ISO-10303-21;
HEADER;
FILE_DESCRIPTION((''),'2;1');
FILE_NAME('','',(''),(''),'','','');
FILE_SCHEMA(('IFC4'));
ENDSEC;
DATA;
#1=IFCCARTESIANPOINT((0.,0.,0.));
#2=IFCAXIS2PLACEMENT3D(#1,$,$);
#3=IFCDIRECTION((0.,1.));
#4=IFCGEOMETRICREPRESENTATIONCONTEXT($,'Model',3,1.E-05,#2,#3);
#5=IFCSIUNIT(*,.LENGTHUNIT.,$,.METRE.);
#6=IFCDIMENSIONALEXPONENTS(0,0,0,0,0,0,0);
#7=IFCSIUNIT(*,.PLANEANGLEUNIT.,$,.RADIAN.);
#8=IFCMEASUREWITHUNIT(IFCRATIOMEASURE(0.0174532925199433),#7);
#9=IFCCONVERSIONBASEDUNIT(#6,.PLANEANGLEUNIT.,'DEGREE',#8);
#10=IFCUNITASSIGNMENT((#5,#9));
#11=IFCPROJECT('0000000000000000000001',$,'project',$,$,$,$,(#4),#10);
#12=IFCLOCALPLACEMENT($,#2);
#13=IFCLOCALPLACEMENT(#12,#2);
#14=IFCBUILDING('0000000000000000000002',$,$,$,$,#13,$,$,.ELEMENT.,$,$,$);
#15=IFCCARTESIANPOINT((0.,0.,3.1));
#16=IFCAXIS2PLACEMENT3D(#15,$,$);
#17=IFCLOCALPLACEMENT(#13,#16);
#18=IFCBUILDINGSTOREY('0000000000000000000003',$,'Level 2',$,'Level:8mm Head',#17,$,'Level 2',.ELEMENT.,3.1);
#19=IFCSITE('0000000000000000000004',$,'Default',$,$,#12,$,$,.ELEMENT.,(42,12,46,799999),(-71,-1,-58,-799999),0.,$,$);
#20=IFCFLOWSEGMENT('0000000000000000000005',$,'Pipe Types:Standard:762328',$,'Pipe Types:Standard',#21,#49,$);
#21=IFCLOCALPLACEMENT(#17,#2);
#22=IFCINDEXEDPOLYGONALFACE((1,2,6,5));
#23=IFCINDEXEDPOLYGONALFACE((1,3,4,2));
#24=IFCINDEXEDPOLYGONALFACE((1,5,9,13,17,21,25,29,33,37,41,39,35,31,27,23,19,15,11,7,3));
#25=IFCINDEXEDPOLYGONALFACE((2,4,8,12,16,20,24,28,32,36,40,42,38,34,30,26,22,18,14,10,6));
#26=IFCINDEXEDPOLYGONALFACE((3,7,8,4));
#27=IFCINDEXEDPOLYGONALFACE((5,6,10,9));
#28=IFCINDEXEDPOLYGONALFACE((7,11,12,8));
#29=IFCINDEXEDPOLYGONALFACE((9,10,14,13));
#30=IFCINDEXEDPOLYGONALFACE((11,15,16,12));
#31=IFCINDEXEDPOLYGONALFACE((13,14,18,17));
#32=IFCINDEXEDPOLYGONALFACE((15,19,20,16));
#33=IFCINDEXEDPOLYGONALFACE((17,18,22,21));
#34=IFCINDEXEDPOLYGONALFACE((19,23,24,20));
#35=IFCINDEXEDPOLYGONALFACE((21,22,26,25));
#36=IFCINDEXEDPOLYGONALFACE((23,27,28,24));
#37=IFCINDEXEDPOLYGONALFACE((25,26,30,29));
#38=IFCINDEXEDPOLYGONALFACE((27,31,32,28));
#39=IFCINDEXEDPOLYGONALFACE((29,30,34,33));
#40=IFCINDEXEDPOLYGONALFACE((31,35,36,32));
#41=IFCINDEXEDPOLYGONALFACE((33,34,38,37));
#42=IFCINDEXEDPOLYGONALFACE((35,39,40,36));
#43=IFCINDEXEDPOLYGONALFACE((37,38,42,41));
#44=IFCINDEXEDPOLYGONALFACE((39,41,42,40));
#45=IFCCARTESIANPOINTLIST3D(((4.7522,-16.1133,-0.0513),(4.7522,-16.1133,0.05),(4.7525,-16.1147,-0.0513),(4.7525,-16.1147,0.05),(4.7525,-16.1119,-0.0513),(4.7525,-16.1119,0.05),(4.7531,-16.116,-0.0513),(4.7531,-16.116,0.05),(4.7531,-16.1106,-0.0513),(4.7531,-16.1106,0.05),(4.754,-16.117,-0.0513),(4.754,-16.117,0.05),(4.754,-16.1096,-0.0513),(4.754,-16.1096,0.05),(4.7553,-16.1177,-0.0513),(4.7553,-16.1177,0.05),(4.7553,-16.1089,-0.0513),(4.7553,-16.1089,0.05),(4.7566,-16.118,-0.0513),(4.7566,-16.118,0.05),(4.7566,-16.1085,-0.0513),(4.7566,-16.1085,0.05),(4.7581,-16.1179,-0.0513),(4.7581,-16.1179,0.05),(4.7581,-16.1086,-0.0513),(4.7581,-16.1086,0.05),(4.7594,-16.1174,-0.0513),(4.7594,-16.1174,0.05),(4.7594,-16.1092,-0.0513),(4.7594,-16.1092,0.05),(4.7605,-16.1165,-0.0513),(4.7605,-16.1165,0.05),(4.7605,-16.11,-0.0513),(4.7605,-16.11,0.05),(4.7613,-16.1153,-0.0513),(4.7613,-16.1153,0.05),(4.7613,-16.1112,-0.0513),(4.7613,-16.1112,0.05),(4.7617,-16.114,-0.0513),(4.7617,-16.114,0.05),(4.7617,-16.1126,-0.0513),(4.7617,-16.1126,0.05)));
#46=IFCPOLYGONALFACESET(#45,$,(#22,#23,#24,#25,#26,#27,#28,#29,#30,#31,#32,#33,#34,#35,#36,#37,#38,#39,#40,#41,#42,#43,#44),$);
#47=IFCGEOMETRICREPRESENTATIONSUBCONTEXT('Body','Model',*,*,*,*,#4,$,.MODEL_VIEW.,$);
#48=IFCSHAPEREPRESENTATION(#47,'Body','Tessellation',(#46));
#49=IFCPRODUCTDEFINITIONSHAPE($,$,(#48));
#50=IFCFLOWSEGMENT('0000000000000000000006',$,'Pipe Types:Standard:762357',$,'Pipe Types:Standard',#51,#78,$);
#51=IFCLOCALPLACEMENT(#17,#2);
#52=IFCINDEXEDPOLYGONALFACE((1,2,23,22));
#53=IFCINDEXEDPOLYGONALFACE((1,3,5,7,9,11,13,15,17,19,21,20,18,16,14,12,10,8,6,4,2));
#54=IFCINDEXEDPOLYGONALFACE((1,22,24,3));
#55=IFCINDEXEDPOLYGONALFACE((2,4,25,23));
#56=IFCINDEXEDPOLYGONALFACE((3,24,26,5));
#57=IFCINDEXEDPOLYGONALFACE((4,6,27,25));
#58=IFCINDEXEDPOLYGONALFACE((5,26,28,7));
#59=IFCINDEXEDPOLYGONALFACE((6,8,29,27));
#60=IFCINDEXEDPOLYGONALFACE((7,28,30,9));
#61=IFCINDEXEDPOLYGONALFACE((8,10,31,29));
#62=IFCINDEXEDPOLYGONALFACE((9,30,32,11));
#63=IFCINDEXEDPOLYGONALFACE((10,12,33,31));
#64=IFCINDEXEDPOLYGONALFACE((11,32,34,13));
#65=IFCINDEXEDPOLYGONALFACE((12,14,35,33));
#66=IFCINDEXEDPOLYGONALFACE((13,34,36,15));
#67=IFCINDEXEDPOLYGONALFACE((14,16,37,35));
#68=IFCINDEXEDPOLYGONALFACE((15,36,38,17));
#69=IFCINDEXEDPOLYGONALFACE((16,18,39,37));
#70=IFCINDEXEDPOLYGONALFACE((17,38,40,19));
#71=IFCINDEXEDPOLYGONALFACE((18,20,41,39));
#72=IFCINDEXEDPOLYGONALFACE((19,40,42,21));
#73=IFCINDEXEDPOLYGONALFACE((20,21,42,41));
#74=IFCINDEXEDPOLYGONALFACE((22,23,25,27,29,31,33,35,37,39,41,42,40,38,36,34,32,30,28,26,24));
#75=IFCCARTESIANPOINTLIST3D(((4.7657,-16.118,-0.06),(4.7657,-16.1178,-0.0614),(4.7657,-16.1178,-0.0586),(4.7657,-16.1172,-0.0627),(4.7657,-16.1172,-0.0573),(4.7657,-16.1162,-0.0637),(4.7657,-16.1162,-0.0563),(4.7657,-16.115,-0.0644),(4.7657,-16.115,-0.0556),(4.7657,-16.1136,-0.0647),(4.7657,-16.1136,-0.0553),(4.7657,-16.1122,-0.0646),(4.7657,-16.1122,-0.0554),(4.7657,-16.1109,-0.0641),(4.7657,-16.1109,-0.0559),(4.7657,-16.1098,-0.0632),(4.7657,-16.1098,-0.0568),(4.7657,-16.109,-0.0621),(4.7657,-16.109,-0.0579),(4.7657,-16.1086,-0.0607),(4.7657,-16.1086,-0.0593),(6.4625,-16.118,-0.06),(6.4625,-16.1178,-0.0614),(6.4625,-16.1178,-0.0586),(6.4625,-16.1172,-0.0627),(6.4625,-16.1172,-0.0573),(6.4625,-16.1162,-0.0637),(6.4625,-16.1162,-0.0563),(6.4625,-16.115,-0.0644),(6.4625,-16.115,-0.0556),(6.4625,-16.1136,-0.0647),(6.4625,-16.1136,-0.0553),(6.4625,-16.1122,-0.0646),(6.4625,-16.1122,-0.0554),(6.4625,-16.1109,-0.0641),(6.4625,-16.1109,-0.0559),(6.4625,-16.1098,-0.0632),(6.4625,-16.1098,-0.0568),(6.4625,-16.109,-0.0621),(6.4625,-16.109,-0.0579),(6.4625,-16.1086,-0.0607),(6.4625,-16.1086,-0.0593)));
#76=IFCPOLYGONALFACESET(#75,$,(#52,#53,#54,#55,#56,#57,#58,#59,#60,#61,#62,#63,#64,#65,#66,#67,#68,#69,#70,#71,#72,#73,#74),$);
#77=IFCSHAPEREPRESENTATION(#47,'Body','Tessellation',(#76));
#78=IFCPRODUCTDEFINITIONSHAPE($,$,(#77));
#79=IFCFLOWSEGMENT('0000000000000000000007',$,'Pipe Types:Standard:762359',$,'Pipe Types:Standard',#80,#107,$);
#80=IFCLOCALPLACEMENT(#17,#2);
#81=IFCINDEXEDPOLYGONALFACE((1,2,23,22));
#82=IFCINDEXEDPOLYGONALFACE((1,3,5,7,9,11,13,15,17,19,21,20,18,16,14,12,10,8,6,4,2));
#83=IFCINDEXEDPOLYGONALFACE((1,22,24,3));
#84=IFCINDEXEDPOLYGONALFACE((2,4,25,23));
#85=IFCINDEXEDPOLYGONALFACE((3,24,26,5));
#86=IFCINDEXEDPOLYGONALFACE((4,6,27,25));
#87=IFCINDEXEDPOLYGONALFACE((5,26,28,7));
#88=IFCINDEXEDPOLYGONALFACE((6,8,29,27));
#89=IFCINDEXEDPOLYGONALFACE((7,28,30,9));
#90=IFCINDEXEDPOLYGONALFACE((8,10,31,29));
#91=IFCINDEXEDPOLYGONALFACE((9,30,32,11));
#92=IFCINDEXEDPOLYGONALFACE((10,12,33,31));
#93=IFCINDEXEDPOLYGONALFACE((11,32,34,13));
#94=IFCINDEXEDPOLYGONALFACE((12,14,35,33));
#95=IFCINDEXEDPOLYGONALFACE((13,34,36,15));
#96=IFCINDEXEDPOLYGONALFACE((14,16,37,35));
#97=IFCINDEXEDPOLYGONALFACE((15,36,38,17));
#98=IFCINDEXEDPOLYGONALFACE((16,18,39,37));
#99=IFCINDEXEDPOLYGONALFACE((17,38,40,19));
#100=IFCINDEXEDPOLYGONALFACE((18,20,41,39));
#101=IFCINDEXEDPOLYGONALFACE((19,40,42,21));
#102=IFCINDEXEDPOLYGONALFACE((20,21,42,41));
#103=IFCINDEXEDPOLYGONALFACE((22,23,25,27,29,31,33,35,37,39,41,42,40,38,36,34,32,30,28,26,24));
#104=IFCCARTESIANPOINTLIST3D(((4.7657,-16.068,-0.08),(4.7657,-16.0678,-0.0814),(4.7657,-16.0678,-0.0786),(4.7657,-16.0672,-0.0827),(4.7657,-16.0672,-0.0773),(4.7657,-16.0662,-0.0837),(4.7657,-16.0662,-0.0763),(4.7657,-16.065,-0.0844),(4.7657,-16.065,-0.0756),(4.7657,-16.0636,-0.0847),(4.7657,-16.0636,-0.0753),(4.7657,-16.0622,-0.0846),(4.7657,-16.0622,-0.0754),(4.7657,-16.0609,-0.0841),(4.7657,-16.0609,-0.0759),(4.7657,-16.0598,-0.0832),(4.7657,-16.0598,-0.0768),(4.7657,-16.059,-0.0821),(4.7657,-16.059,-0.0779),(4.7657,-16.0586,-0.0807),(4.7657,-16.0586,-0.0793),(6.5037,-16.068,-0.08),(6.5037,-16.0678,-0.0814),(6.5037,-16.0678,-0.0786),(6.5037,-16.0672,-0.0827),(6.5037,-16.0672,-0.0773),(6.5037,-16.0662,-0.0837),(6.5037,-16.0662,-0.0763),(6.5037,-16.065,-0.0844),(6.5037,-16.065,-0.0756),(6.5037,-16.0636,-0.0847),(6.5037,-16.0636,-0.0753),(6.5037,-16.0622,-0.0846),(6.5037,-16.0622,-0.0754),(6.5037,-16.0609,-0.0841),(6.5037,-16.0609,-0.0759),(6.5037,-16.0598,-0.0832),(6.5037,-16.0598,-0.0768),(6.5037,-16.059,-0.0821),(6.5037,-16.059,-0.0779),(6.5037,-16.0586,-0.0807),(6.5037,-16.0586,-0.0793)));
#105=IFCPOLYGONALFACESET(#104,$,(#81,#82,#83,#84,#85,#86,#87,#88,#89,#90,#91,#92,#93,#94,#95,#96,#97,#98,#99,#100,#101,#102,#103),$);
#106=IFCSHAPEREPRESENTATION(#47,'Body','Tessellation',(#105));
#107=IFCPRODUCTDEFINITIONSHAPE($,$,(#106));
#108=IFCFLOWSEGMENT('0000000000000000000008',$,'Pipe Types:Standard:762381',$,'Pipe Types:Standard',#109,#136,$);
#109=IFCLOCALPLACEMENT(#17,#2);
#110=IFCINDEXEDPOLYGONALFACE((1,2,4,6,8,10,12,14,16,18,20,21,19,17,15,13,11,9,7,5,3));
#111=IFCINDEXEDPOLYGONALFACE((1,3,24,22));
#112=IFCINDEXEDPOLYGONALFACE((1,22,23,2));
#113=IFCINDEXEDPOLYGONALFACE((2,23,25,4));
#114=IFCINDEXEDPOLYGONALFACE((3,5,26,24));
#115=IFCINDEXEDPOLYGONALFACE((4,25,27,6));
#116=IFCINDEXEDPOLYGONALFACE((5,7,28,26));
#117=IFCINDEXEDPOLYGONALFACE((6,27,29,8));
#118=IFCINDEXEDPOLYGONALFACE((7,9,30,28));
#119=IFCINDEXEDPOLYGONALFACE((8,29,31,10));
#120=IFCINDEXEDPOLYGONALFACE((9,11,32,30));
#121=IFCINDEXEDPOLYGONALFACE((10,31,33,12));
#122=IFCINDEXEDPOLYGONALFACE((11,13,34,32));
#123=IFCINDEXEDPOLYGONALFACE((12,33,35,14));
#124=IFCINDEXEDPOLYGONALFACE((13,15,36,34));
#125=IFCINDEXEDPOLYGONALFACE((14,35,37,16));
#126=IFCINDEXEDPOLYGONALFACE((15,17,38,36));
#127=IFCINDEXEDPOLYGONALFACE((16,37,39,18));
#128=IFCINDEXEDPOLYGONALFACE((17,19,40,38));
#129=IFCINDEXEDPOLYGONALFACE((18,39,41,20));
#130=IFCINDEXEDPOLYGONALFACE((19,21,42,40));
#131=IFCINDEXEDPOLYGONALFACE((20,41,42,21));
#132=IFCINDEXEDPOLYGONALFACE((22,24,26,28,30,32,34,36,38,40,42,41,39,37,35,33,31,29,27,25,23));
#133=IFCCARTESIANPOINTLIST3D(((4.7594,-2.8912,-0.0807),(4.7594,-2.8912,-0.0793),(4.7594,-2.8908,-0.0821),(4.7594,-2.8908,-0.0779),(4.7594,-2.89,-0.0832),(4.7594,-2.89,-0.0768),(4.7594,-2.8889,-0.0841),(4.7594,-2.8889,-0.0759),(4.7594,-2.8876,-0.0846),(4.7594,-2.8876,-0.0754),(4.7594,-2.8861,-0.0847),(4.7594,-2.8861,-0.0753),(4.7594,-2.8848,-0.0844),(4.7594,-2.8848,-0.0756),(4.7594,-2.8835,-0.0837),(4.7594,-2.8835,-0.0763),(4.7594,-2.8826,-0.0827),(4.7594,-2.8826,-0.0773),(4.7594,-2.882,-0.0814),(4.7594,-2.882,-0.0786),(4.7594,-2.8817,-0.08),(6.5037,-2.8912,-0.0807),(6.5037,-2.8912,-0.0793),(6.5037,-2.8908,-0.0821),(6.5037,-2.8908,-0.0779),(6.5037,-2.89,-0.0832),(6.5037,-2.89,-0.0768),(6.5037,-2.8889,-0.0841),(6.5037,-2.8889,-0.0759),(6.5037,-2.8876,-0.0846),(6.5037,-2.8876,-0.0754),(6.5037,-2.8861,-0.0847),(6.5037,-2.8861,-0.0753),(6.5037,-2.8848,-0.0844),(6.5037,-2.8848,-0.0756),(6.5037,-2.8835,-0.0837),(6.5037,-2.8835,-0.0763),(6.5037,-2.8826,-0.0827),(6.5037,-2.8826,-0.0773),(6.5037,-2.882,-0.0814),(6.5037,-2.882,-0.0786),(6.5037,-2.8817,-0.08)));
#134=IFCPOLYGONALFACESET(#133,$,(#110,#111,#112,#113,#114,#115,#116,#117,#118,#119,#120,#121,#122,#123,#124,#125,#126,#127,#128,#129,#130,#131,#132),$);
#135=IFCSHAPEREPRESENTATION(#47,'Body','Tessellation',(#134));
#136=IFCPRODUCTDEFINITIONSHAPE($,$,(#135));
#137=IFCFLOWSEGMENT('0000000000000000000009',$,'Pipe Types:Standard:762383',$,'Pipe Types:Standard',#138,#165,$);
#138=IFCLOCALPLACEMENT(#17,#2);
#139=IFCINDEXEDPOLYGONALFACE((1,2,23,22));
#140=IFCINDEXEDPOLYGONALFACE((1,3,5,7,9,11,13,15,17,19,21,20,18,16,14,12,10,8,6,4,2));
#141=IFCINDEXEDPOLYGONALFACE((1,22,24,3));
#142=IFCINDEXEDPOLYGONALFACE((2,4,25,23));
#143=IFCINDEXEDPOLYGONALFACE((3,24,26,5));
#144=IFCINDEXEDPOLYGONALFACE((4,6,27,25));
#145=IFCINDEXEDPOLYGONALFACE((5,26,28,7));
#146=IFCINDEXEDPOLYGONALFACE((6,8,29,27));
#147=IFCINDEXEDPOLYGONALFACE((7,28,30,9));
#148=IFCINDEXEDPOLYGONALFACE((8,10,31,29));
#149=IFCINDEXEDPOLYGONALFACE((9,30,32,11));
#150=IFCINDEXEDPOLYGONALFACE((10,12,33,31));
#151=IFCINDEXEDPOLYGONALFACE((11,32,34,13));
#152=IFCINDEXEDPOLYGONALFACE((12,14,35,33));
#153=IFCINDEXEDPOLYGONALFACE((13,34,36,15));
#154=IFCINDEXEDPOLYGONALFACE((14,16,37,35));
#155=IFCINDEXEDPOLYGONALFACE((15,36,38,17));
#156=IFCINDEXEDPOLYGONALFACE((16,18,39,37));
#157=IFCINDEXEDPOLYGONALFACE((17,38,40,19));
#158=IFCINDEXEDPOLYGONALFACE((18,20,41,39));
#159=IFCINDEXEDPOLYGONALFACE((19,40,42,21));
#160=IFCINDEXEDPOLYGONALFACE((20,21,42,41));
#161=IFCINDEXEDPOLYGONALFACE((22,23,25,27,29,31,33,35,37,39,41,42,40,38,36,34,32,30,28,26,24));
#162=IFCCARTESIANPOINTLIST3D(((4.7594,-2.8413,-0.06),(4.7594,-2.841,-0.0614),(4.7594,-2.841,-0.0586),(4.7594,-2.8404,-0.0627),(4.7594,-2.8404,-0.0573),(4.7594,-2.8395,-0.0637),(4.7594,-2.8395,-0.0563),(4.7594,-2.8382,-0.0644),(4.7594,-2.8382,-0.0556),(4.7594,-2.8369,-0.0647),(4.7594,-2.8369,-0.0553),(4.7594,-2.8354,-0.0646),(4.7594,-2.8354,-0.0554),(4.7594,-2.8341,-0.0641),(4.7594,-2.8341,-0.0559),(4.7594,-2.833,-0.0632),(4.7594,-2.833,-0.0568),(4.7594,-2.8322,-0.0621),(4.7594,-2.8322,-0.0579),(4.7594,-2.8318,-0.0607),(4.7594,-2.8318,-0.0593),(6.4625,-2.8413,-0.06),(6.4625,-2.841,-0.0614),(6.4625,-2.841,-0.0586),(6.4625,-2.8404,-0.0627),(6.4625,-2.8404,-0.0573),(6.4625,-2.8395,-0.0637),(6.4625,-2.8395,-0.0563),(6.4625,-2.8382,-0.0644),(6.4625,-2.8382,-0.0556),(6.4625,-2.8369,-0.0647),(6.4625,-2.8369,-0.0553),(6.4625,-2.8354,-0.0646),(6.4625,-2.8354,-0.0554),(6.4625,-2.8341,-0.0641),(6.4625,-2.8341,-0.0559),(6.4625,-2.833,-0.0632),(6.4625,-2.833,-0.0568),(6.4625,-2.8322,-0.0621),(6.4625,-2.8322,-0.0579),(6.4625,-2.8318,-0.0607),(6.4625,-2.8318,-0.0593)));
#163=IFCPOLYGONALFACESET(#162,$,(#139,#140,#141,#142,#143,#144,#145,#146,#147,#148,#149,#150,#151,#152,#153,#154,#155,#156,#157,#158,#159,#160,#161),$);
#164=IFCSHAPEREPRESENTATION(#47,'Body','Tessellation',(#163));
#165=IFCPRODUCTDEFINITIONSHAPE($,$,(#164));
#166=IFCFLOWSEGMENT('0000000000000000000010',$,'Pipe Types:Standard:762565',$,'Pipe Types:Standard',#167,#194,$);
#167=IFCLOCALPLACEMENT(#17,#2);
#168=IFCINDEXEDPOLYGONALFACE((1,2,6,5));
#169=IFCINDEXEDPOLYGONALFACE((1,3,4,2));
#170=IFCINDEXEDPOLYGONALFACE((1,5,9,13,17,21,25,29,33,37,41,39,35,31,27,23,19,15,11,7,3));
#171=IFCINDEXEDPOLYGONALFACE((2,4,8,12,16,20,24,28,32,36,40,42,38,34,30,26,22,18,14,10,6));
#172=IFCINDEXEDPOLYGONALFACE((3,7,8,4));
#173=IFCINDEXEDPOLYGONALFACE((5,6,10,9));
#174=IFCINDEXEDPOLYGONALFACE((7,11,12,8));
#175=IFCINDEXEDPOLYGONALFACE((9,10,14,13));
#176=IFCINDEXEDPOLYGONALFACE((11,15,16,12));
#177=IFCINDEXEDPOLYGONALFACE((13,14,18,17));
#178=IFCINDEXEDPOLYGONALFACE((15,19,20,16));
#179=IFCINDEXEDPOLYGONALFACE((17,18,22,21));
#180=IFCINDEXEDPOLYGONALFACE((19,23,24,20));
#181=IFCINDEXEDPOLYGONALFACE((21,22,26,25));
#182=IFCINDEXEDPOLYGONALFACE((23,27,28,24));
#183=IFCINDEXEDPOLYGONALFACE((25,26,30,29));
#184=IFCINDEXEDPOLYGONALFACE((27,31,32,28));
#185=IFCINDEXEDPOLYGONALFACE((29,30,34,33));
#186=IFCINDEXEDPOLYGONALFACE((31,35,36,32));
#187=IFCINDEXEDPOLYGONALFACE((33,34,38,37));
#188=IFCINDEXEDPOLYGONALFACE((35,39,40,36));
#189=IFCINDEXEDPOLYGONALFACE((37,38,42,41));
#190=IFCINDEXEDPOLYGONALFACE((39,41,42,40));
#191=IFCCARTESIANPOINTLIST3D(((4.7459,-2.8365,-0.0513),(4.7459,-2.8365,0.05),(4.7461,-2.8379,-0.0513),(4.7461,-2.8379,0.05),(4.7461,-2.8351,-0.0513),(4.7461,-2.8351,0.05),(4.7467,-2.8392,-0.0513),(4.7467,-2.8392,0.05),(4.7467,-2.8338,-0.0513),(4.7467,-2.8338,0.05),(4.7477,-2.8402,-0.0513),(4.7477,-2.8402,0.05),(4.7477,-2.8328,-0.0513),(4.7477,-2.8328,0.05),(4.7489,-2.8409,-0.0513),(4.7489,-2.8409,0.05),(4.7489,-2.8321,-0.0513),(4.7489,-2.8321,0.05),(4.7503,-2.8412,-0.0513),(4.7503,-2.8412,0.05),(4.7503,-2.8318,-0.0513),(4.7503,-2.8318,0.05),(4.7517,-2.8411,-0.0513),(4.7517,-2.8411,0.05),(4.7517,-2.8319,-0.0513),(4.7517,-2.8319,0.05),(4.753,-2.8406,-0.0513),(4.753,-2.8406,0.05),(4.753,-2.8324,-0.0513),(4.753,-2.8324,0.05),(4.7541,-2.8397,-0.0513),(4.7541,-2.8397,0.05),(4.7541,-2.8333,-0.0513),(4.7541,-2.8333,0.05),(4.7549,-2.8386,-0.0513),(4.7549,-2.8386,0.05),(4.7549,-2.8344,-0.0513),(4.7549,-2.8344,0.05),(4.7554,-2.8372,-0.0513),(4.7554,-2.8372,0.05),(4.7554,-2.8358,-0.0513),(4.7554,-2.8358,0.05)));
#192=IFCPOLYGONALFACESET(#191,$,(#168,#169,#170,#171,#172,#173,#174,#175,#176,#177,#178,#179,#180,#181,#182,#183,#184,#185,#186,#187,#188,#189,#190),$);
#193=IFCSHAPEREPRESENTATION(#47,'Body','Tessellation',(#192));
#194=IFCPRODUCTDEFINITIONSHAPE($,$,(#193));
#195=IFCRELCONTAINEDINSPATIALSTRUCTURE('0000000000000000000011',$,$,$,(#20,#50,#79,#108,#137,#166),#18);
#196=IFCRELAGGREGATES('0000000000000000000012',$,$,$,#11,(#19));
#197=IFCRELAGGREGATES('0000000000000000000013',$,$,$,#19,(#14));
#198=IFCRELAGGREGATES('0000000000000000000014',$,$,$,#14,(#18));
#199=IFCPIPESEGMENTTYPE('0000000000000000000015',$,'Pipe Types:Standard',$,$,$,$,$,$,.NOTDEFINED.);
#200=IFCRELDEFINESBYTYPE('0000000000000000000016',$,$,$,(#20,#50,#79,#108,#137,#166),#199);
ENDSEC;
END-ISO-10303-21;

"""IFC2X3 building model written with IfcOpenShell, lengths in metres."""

from ifc_helpers import new_model, entity, si_unit, converted_unit, direction, frame, frame_2d, origin, origin_2d_with_axis, place, context, subcontext, project, spatial, circle, extrude, type_object, element, save


model = new_model("IFC2X3")

# Units and contexts
model_context = context("Model", 3, precision=1e-05, world=origin(), true_north=direction((0.0, 1.0)))
body_context = subcontext(model_context, "Body", "Model", "MODEL_VIEW")
ifc_project = project(units=[si_unit("LENGTHUNIT", "METRE"), converted_unit("PLANEANGLEUNIT", "DEGREE", entity("IfcRatioMeasure", 0.0174532925199433), si_unit("PLANEANGLEUNIT", "RADIAN"), dimensions=[0, 0, 0, 0, 0, 0, 0])], contexts=[model_context])

# Site, building, storey
site_placement = place(None, origin())
site = spatial("IfcSite", under=ifc_project, at=site_placement, Name="Default", CompositionType="ELEMENT", RefLatitude=(42, 12, 46, 799999), RefLongitude=(-71, -1, -58, -799999), RefElevation=0.0)
building_placement = place(site_placement, origin())
building = spatial("IfcBuilding", under=site, at=building_placement, CompositionType="ELEMENT")
storey_placement = place(building_placement, frame((0.0, 0.0, 3.1)))
storey = spatial("IfcBuildingStorey", under=building, at=storey_placement, Name="Level 2", ObjectType="Level:8mm Head", LongName="Level 2", CompositionType="ELEMENT", Elevation=3.1)

# Flow segments
pipe_segment_type = type_object("IfcPipeSegmentType", Name="Pipe Types:Standard", PredefinedType="NOTDEFINED")
flow_segment_1_placement = place(storey_placement, origin())
element("IfcFlowSegment", 1, at=flow_segment_1_placement, inside=storey, type_object=pipe_segment_type, Name="Pipe Types:Standard:762328", ObjectType="Pipe Types:Standard", context=body_context, shape_type="SweptSolid", body=[
    extrude(circle(Radius=0.0048, at=origin_2d_with_axis()), frame((4.757, -16.1133, -0.0513), z_axis=(0.0, 0.0, 1.0), x_axis=(-1.0, 0.0, 0.0)), (0.0, 0.0, 1.0), 0.1013),
])
flow_segment_2_placement = place(storey_placement, origin())
element("IfcFlowSegment", 2, at=flow_segment_2_placement, inside=storey, type_object=pipe_segment_type, Name="Pipe Types:Standard:762357", ObjectType="Pipe Types:Standard", context=body_context, shape_type="SweptSolid", body=[
    extrude(circle(Radius=0.0048, at=origin_2d_with_axis()), frame((4.7657, -16.1133, -0.06), z_axis=(1.0, 0.0, 0.0), x_axis=(0.0, -1.0, 0.0)), (0.0, 0.0, 1.0), 1.6968),
])
flow_segment_3_placement = place(storey_placement, origin())
element("IfcFlowSegment", 3, at=flow_segment_3_placement, inside=storey, type_object=pipe_segment_type, Name="Pipe Types:Standard:762359", ObjectType="Pipe Types:Standard", context=body_context, shape_type="SweptSolid", body=[
    extrude(circle(Radius=0.0048, at=origin_2d_with_axis()), frame((4.7657, -16.0633, -0.08), z_axis=(1.0, 0.0, 0.0), x_axis=(0.0, -1.0, 0.0)), (0.0, 0.0, 1.0), 1.738),
])
flow_segment_4_placement = place(storey_placement, origin())
element("IfcFlowSegment", 4, at=flow_segment_4_placement, inside=storey, type_object=pipe_segment_type, Name="Pipe Types:Standard:762381", ObjectType="Pipe Types:Standard", context=body_context, shape_type="SweptSolid", body=[
    extrude(circle(Radius=0.0048, at=frame_2d((0.0, 0.0), x_axis=(1.0, 0.0))), frame((4.7594, -2.8865, -0.08), z_axis=(1.0, 0.0, 0.0), x_axis=(0.0, 1.0, 0.0)), (0.0, 0.0, 1.0), 1.7444),
])
flow_segment_5_placement = place(storey_placement, origin())
element("IfcFlowSegment", 5, at=flow_segment_5_placement, inside=storey, type_object=pipe_segment_type, Name="Pipe Types:Standard:762383", ObjectType="Pipe Types:Standard", context=body_context, shape_type="SweptSolid", body=[
    extrude(circle(Radius=0.0048, at=origin_2d_with_axis()), frame((4.7594, -2.8365, -0.06), z_axis=(1.0, 0.0, 0.0), x_axis=(0.0, -1.0, 0.0)), (0.0, 0.0, 1.0), 1.7031),
])
flow_segment_6_placement = place(storey_placement, origin())
element("IfcFlowSegment", 6, at=flow_segment_6_placement, inside=storey, type_object=pipe_segment_type, Name="Pipe Types:Standard:762565", ObjectType="Pipe Types:Standard", context=body_context, shape_type="SweptSolid", body=[
    extrude(circle(Radius=0.0048, at=origin_2d_with_axis()), frame((4.7506, -2.8365, -0.0513), z_axis=(0.0, 0.0, 1.0), x_axis=(-1.0, 0.0, 0.0)), (0.0, 0.0, 1.0), 0.1013),
])

save(model, "model.ifc")
